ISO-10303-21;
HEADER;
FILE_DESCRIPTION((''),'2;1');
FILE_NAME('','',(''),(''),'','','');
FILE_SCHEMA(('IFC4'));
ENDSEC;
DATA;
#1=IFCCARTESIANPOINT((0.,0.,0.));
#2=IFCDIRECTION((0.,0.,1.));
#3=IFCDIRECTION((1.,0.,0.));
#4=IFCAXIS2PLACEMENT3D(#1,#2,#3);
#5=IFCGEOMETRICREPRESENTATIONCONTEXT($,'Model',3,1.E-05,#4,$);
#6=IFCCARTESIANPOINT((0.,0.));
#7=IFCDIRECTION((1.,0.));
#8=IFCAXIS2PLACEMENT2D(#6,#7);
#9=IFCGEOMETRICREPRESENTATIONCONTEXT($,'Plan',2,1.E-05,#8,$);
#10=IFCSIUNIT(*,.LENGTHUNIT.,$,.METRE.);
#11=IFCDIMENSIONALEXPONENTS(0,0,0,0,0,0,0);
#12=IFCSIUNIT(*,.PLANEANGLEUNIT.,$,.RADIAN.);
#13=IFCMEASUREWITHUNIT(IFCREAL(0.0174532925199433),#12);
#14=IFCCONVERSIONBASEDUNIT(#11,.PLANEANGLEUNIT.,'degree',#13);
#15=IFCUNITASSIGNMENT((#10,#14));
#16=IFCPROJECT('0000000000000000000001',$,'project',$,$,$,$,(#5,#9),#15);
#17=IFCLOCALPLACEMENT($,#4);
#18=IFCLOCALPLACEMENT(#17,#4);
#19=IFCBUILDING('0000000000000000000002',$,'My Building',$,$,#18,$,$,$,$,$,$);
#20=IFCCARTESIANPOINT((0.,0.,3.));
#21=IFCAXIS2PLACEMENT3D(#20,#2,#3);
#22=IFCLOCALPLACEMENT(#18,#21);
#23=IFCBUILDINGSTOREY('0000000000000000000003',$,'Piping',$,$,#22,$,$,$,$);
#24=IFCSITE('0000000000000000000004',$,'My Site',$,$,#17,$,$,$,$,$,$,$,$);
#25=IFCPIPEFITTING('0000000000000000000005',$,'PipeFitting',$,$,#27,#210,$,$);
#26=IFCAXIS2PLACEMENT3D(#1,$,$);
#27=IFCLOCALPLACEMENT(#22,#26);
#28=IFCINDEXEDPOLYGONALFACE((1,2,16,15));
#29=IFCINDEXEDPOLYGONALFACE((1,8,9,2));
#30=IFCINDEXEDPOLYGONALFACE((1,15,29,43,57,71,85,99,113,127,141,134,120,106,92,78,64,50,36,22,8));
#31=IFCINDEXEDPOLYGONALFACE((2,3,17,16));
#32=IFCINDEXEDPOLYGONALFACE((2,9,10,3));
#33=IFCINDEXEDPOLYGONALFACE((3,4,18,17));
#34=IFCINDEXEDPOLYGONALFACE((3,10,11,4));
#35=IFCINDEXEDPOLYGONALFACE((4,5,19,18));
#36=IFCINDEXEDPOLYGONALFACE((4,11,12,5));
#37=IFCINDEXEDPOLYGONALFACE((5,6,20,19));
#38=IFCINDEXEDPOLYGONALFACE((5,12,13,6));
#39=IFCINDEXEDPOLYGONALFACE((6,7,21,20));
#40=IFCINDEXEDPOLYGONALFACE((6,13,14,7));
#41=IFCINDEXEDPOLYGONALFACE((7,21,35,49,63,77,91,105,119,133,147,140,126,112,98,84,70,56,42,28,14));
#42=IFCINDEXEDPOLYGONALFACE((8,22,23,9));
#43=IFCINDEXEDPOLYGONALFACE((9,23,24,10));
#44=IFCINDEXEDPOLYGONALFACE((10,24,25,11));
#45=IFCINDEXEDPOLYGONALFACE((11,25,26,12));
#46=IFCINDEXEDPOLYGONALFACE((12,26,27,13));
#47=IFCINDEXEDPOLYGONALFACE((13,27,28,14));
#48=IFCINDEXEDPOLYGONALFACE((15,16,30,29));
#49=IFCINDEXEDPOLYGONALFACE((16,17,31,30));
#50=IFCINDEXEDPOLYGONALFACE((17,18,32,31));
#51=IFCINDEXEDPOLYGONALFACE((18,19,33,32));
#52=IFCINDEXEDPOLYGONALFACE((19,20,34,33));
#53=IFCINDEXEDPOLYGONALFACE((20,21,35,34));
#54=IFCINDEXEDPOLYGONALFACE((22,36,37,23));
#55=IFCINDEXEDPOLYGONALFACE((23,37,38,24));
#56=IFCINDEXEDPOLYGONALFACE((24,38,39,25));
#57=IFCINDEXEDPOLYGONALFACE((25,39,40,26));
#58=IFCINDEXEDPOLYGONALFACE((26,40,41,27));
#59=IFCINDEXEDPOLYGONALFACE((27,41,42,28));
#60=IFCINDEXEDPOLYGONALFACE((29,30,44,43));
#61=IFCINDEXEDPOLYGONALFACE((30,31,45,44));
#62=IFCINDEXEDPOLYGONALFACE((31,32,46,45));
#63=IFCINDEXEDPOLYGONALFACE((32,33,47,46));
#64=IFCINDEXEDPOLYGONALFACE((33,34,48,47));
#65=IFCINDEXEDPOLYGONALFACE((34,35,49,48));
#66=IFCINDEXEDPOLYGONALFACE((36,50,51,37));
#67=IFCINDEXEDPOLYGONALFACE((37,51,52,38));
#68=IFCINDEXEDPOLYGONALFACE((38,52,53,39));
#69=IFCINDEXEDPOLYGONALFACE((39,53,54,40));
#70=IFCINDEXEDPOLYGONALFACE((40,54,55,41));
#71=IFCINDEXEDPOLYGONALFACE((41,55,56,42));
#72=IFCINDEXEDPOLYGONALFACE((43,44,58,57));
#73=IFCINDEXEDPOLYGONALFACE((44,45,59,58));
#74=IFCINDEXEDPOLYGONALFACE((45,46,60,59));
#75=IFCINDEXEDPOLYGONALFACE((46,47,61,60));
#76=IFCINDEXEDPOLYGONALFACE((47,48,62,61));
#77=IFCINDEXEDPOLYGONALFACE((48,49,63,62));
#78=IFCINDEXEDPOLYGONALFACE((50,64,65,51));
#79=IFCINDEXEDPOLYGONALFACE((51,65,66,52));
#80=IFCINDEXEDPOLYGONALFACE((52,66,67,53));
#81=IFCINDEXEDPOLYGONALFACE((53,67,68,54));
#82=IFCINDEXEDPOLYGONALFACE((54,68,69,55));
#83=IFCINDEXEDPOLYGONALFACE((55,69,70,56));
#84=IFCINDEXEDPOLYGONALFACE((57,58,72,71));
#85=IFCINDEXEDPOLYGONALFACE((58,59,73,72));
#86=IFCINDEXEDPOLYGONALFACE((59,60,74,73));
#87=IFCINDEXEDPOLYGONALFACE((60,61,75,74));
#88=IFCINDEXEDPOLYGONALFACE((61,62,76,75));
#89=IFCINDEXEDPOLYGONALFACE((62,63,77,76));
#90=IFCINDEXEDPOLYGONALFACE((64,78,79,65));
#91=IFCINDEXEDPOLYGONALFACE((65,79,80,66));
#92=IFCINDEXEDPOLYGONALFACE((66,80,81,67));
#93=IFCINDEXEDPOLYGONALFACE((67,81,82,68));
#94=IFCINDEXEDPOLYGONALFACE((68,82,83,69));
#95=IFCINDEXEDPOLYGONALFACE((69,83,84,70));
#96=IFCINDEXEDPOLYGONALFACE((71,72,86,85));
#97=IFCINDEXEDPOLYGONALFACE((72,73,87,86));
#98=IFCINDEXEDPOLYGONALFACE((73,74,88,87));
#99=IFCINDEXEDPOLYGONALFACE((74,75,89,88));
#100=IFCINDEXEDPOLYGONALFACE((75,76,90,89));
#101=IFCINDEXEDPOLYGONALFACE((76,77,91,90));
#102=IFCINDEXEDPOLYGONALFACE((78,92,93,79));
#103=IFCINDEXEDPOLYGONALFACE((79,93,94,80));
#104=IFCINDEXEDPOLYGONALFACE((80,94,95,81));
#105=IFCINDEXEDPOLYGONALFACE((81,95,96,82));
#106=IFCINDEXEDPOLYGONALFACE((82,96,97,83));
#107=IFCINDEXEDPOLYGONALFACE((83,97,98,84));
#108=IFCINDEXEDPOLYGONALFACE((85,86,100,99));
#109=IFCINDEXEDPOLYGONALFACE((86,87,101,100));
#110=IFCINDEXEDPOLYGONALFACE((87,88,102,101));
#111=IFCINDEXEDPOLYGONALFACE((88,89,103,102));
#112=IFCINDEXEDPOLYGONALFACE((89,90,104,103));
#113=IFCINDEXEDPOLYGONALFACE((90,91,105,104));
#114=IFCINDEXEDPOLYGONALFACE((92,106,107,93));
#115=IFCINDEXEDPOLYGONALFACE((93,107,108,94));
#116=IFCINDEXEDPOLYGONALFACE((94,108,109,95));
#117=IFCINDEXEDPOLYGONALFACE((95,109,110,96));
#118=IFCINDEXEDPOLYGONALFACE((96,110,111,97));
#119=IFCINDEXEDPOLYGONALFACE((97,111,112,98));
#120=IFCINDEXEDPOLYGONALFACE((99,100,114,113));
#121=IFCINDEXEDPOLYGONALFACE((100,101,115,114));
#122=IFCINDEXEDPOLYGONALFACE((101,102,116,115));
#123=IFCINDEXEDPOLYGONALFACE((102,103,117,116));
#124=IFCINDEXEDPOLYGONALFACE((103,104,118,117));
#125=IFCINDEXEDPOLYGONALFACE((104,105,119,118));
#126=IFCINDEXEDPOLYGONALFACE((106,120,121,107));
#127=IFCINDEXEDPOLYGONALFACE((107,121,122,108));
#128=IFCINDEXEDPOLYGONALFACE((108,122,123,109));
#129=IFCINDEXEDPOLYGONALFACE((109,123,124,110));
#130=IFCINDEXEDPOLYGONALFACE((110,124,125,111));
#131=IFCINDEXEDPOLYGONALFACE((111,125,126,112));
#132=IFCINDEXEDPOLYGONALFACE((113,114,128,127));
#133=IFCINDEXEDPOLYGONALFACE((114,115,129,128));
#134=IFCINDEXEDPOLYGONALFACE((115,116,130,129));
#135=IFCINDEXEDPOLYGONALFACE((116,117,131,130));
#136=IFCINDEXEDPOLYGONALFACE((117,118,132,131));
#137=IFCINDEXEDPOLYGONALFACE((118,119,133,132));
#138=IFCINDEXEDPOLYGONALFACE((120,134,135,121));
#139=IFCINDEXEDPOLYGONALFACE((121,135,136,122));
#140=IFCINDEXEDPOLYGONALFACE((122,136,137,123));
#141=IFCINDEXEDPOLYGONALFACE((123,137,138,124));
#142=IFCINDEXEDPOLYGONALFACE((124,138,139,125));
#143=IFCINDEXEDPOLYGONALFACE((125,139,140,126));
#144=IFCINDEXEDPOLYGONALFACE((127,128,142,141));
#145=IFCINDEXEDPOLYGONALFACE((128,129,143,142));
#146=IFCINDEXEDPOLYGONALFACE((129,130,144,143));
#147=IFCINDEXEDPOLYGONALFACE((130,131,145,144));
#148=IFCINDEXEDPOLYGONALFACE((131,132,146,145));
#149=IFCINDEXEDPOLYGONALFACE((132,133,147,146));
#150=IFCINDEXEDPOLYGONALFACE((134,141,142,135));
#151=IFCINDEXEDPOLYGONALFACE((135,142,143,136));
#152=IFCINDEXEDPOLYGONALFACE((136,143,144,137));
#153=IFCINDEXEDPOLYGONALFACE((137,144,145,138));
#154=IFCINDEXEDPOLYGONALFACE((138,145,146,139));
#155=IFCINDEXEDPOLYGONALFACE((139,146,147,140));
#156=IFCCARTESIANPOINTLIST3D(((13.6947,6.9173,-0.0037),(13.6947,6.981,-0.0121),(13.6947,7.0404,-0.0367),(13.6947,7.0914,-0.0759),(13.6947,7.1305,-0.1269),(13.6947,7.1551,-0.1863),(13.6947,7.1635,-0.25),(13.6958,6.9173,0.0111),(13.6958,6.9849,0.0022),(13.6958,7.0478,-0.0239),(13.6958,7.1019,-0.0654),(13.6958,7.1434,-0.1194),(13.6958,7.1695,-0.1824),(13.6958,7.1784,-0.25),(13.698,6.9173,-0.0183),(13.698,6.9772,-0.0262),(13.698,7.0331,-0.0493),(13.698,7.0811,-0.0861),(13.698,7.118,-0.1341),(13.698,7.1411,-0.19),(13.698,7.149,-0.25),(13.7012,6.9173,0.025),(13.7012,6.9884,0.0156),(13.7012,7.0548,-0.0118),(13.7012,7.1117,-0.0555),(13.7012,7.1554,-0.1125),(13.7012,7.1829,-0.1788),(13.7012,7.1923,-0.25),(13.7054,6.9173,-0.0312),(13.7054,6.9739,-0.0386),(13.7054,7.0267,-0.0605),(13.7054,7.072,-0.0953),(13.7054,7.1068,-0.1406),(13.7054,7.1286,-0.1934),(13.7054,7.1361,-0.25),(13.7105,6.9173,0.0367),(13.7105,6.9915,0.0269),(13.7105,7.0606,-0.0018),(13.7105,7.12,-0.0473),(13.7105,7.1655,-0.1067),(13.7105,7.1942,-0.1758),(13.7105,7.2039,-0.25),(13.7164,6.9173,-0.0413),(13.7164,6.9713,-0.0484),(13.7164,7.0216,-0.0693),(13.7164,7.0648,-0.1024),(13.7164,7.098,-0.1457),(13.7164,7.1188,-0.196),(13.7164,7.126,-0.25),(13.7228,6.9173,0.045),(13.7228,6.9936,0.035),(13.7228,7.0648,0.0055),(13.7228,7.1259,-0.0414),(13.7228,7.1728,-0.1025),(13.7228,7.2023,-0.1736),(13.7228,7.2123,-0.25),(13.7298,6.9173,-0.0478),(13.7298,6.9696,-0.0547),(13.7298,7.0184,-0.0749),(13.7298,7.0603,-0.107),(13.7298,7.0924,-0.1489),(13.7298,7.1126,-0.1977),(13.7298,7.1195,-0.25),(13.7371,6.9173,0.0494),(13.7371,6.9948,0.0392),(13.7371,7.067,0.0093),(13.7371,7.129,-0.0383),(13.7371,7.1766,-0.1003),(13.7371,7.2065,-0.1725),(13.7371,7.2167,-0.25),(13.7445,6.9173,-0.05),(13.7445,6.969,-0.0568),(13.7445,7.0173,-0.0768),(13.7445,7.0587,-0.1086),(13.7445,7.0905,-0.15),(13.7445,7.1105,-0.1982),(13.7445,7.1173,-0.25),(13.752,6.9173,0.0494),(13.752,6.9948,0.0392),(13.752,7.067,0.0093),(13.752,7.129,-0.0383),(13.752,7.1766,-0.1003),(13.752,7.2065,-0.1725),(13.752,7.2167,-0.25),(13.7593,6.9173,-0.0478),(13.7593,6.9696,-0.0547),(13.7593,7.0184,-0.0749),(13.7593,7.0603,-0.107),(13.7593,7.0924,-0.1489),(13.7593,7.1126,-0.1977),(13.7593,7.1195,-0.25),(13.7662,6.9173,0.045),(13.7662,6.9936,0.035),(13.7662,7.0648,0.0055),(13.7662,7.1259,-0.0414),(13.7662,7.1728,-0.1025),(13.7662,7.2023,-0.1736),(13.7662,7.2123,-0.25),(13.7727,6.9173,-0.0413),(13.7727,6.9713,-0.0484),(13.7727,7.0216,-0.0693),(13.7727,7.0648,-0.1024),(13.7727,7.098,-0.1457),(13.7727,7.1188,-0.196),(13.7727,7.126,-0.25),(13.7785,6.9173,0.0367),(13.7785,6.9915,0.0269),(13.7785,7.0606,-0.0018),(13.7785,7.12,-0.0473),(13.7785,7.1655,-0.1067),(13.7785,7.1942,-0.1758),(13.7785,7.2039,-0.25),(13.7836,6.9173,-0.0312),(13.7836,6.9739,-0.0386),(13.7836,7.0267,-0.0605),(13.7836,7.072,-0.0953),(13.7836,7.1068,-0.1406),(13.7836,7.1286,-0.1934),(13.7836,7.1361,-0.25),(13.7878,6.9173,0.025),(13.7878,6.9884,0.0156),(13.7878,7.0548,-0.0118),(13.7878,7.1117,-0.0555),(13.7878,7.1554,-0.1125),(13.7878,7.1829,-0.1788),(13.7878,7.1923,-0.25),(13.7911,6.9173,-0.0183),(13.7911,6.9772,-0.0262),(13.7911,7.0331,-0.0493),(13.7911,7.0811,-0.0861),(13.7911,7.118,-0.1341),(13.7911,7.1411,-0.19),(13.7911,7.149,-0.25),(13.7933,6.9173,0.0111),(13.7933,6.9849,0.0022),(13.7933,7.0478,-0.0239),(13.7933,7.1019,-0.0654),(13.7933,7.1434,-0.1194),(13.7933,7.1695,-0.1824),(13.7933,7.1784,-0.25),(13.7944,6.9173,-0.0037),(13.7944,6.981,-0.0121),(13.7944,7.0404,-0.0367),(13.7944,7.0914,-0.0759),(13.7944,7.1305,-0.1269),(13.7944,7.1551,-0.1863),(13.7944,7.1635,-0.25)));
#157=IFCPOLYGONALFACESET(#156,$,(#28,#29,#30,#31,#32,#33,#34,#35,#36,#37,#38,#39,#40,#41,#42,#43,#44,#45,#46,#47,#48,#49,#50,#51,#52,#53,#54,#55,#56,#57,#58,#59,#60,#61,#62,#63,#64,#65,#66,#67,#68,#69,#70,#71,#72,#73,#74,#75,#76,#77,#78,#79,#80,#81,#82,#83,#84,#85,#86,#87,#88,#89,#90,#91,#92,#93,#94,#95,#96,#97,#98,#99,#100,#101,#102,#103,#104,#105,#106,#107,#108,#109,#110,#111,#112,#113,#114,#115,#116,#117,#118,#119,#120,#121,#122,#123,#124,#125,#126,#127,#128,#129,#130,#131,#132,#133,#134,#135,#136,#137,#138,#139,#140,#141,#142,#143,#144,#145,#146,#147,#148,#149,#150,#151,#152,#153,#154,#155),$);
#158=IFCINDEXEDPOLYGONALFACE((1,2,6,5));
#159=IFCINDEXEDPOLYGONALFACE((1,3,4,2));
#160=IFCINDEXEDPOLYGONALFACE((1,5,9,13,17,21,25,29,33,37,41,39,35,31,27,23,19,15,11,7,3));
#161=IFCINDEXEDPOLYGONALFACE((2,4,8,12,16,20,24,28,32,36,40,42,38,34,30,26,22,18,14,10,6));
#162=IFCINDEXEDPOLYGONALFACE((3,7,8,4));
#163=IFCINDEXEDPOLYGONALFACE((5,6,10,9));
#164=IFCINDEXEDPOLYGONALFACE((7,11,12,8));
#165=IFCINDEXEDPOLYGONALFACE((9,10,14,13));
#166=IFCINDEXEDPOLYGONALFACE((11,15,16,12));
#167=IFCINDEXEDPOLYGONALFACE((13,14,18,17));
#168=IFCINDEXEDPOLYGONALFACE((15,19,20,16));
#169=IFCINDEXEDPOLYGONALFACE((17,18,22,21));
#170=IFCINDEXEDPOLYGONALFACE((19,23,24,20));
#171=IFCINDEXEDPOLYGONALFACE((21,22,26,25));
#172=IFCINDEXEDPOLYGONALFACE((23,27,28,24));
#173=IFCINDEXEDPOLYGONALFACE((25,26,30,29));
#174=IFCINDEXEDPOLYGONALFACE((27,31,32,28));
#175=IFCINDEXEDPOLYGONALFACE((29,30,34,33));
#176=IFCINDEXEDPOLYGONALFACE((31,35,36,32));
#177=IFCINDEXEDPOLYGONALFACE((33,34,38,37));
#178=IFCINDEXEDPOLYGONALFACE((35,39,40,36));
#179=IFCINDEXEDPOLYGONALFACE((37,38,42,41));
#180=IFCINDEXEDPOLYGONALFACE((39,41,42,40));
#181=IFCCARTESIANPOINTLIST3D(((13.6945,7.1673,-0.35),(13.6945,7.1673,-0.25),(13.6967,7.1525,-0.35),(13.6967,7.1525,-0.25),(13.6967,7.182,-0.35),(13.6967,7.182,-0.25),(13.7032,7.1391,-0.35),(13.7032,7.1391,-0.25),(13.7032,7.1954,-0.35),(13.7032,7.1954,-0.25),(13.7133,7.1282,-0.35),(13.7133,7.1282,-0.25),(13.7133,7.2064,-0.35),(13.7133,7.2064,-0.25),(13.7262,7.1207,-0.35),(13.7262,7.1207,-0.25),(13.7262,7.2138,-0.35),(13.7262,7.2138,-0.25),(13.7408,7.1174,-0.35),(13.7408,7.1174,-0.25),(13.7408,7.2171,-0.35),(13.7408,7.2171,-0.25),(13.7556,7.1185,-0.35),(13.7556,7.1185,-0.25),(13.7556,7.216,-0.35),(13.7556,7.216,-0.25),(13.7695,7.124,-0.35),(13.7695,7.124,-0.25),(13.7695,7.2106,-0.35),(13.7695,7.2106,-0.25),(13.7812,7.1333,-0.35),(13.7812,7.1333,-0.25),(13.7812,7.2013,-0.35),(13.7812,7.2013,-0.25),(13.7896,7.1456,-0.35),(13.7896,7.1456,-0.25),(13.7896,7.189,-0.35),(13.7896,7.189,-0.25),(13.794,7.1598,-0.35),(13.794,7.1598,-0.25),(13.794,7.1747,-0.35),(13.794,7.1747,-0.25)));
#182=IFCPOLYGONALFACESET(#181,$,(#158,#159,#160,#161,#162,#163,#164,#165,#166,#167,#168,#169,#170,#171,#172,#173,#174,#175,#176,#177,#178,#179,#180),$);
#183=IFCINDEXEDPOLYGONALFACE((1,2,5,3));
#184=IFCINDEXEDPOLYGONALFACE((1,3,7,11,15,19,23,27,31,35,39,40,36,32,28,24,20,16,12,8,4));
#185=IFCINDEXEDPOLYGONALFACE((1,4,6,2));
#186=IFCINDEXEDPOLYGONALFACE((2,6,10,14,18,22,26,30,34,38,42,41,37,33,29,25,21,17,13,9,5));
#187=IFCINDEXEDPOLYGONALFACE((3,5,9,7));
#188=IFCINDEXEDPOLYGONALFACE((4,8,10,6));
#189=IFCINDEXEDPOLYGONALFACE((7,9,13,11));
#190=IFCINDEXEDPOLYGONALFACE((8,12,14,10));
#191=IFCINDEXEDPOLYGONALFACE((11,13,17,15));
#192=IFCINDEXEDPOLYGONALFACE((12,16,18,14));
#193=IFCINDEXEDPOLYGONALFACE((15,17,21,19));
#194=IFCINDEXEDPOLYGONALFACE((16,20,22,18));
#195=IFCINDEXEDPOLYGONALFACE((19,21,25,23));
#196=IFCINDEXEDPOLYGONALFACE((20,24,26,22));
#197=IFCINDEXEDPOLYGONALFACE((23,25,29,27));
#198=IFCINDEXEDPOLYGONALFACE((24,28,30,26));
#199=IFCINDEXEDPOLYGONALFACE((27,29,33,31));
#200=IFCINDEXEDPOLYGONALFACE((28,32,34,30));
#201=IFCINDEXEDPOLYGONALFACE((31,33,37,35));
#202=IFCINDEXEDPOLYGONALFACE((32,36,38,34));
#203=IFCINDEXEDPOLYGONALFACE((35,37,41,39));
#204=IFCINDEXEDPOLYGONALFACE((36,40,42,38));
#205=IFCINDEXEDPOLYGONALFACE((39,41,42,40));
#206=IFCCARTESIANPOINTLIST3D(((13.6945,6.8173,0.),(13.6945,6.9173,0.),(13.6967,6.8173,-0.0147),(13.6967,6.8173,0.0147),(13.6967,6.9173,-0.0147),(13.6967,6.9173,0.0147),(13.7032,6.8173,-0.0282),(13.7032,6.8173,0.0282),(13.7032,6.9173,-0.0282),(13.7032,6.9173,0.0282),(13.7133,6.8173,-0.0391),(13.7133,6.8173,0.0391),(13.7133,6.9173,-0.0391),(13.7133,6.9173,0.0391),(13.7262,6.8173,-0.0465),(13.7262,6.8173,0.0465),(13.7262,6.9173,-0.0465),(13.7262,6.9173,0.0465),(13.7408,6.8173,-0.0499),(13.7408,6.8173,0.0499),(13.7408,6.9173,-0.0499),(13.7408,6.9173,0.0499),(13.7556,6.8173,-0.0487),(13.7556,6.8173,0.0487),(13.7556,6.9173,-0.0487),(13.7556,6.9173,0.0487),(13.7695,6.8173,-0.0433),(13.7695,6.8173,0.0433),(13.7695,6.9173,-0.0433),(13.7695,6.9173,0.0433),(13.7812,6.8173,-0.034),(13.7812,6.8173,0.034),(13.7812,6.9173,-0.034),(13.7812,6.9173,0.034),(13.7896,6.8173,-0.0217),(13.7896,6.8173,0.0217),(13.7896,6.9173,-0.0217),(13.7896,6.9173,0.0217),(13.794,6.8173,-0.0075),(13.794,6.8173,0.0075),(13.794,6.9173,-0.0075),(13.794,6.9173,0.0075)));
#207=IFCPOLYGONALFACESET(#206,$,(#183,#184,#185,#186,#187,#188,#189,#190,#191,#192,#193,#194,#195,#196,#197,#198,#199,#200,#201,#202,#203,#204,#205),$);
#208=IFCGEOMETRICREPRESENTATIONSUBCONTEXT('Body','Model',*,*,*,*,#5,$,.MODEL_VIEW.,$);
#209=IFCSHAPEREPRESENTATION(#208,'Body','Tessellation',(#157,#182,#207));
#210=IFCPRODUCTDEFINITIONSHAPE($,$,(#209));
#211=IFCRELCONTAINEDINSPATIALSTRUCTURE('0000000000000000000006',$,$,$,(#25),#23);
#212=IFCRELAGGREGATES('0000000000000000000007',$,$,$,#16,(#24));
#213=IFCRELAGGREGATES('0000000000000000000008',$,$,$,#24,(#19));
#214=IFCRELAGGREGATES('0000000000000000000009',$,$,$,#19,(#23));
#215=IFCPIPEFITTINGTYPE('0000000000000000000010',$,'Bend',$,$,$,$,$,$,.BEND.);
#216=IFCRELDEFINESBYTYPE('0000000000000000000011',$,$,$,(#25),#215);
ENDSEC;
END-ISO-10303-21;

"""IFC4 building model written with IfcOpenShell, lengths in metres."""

from ifc_helpers import new_model, entity, si_unit, converted_unit, frame, origin_with_axes, origin_2d_with_axis, place, context, subcontext, project, spatial, circle, extrude, source, transform, mapped, type_object, type_shapes, element, save


model = new_model("IFC4")

# Units and contexts
model_context = context("Model", 3, precision=1e-05, world=origin_with_axes())
plan_context = context("Plan", 2, precision=1e-05, world=origin_2d_with_axis())
body_context = subcontext(model_context, "Body", "Model", "MODEL_VIEW")
ifc_project = project(units=[si_unit("LENGTHUNIT", "METRE"), converted_unit("PLANEANGLEUNIT", "degree", entity("IfcReal", 0.0174532925199433), si_unit("PLANEANGLEUNIT", "RADIAN"), dimensions=[0, 0, 0, 0, 0, 0, 0])], contexts=[model_context, plan_context])

# Site, building, storey
site_placement = place(None, origin_with_axes())
site = spatial("IfcSite", under=ifc_project, at=site_placement, Name="My Site")
building_placement = place(site_placement, origin_with_axes())
building = spatial("IfcBuilding", under=site, at=building_placement, Name="My Building")
storey_placement = place(building_placement, frame((0.0, 0.0, 3.0), z_axis=(0.0, 0.0, 1.0), x_axis=(1.0, 0.0, 0.0)))
storey = spatial("IfcBuildingStorey", under=building, at=storey_placement, Name="Piping")

# Pipe fitting
pipe_fitting_type = type_object("IfcPipeFittingType", Name="Bend", PredefinedType="BEND")
shared_shape = source(origin_with_axes(), body_context, "Body", "SolidModel", [
    entity("IfcSweptDiskSolid", entity("IfcIndexedPolyCurve", entity("IfcCartesianPointList3D", [[0.0, 0.0, -0.1], [0.0, -0.0732, -0.2768], [0.0, -0.25, -0.35]]), [entity("IfcArcIndex", [1, 2, 3])]), 0.05),
    extrude(circle(Radius=0.05), origin_with_axes(), (0.0, 0.0, -1.0), 0.1),
    extrude(circle(Radius=0.05), frame((0.0, -0.25, -0.35), z_axis=(0.0, -1.0, 0.0), x_axis=(1.0, 0.0, 0.0)), (0.0, 0.0, 1.0), 0.1),
])
type_shapes(pipe_fitting_type, [shared_shape])
for number, where, z_axis, x_axis, name in (
    (1, (13.7445, 7.1673, -0.35), (0.0, 0.0, -1.0), (-1.0, 0.0, 0.0), "PipeFitting"),
):
    element("IfcPipeFitting", number, at=place(storey_placement, frame(where, z_axis=z_axis, x_axis=x_axis)), inside=storey, type_object=pipe_fitting_type, Name=name, context=body_context, shape_type="MappedRepresentation", body=[
        mapped(shared_shape, transform((0.0, 0.0, 0.0), x_axis=(1.0, 0.0, 0.0), y_axis=(0.0, 1.0, 0.0), z_axis=(0.0, 0.0, 1.0), scale=1.0)),
    ])

save(model, "model.ifc")
